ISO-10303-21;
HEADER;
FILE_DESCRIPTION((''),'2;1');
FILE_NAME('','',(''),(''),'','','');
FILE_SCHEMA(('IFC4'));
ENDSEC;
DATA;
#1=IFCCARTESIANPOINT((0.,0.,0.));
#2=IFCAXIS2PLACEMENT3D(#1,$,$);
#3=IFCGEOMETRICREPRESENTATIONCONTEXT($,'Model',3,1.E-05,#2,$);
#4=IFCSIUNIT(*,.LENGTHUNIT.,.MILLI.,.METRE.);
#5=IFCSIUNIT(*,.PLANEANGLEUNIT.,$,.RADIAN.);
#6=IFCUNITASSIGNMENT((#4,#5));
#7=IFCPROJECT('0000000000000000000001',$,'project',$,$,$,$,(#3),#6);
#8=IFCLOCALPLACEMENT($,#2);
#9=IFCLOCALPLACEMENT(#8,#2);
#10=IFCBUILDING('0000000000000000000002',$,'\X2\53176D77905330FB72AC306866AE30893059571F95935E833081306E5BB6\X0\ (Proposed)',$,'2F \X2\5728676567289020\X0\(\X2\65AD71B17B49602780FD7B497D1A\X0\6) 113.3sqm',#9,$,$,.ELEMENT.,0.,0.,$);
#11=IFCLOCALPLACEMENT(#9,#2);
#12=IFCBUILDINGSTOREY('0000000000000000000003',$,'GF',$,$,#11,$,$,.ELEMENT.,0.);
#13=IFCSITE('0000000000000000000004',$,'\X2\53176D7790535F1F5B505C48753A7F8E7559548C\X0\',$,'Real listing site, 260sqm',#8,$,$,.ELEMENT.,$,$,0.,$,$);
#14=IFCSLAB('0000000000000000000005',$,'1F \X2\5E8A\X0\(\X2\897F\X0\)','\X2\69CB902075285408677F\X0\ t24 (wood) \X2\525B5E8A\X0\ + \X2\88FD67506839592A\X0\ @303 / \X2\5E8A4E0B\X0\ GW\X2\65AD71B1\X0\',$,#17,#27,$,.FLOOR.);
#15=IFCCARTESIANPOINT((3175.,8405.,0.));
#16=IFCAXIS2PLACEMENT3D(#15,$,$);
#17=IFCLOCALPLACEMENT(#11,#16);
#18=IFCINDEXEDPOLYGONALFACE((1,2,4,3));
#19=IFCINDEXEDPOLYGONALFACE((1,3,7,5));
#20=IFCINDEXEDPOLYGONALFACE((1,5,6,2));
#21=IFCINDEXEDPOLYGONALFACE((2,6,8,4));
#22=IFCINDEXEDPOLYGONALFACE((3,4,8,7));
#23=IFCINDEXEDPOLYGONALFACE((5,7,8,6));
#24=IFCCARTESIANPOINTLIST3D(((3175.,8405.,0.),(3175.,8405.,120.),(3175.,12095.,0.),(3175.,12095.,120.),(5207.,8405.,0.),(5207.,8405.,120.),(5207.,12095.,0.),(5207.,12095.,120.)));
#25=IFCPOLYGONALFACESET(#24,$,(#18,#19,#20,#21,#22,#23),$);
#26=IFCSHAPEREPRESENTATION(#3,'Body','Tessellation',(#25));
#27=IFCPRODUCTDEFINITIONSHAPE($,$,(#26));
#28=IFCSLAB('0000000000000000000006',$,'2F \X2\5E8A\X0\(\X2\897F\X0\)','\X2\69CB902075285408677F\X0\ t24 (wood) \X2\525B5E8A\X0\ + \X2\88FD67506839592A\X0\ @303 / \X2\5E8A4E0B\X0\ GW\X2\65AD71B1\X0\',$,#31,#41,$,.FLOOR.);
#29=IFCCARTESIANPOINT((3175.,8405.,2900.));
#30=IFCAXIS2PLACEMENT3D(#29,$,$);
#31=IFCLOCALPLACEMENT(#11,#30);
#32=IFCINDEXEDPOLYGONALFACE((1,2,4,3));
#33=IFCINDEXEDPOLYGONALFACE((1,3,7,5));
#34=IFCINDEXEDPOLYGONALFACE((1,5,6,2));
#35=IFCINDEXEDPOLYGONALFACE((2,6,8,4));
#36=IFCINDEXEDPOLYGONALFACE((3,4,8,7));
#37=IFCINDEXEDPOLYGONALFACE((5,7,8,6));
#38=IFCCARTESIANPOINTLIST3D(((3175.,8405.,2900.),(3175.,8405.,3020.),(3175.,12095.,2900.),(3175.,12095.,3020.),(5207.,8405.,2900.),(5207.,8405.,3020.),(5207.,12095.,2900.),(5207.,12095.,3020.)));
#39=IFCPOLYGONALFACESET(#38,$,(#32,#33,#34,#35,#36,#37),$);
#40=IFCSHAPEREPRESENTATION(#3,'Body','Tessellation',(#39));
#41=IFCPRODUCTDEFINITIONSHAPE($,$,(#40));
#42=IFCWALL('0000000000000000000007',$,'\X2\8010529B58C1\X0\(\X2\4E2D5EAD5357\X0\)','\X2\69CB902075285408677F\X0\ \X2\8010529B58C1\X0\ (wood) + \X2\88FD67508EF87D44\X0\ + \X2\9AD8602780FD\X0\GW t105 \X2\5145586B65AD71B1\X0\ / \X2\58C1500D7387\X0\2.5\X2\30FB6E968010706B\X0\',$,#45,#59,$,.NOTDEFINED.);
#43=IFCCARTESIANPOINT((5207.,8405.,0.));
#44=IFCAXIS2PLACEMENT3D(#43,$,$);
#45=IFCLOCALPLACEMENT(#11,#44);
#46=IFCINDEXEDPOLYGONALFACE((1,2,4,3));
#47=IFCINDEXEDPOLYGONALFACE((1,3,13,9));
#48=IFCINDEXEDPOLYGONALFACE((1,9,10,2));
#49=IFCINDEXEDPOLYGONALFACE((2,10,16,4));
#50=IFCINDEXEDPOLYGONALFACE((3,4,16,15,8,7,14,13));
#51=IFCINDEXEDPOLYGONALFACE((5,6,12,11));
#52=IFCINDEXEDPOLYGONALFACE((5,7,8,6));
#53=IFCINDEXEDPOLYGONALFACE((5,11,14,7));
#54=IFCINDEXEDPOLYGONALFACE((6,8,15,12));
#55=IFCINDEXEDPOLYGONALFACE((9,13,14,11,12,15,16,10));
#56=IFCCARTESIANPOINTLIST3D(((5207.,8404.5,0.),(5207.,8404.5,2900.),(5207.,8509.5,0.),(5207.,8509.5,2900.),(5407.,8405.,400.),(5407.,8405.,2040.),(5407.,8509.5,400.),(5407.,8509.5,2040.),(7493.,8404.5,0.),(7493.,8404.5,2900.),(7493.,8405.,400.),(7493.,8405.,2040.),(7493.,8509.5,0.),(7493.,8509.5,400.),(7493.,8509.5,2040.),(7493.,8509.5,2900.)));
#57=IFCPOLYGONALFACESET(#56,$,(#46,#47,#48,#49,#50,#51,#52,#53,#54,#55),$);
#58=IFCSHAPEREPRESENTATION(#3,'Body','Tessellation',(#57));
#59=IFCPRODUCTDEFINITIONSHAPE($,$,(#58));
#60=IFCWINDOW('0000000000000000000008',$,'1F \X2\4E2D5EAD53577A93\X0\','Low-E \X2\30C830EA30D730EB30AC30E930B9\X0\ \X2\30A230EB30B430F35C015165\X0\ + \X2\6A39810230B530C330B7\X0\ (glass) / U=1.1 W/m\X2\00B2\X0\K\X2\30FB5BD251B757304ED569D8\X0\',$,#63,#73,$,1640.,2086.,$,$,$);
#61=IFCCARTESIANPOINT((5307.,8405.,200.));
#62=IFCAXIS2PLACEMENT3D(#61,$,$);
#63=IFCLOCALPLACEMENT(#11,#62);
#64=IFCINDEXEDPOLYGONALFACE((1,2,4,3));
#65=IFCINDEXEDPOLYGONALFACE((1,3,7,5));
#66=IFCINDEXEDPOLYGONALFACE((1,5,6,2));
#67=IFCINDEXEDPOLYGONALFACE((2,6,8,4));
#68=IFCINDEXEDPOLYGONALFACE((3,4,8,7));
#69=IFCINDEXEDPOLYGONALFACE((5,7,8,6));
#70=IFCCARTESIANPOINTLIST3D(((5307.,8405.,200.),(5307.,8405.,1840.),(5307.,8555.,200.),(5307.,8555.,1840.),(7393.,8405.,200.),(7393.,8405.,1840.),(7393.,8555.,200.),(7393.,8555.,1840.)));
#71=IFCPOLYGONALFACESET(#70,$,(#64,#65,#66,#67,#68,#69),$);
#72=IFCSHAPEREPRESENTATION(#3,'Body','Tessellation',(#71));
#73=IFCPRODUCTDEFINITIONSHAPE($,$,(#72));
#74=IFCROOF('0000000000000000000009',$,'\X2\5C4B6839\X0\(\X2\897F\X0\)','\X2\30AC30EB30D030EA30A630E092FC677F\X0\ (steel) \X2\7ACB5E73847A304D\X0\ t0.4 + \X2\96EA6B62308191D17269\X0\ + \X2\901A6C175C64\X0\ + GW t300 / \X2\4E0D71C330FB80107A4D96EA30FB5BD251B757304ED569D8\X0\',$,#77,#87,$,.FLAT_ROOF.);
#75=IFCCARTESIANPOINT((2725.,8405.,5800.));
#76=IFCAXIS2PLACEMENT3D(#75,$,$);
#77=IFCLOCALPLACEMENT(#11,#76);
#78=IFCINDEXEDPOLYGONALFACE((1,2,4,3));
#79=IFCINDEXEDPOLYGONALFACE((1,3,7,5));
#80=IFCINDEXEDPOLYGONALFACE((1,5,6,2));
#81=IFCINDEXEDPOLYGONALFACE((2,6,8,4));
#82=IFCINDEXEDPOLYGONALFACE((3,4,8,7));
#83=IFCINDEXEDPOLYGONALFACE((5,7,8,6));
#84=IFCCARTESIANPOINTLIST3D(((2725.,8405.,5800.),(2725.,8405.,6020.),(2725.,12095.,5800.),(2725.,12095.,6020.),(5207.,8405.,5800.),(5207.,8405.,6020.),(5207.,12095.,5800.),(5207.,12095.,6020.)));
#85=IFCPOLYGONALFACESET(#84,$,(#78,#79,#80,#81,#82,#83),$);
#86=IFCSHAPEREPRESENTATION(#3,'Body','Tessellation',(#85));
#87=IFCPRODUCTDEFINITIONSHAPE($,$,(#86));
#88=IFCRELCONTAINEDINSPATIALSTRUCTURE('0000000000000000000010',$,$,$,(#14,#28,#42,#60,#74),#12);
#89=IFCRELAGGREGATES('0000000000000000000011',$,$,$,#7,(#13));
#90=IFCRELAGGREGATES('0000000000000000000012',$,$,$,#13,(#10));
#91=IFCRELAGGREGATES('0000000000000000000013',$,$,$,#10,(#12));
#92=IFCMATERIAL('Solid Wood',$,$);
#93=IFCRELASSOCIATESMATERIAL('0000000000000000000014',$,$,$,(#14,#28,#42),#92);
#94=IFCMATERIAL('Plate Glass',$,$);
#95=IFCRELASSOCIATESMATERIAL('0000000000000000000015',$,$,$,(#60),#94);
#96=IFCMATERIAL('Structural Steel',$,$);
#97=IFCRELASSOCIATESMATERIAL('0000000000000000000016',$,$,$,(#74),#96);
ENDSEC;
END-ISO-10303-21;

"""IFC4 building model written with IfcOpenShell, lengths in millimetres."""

from ifc_helpers import new_model, si_unit, frame, frame_2d, origin, place, context, project, spatial, rectangle, extrude, material, element, fill, save


model = new_model("IFC4")

# Units and contexts
model_context = context("Model", 3, precision=1e-05, world=origin())
ifc_project = project(units=[si_unit("LENGTHUNIT", "METRE", prefix="MILLI"), si_unit("PLANEANGLEUNIT", "RADIAN")], contexts=[model_context])

# Site, building, storey
site_placement = place(None, origin())
site = spatial("IfcSite", under=ifc_project, at=site_placement, Name="北海道弟子屈町美留和", ObjectType="Real listing site, 260sqm", CompositionType="ELEMENT", RefElevation=0.0)
building_placement = place(site_placement, origin())
building = spatial("IfcBuilding", under=site, at=building_placement, Name="北海道・犬と暮らす土間広めの家 (Proposed)", ObjectType="2F 在来木造(断熱等性能等級6) 113.3sqm", CompositionType="ELEMENT", ElevationOfRefHeight=0.0, ElevationOfTerrain=0.0)
storey_placement = place(building_placement, origin())
storey = spatial("IfcBuildingStorey", under=building, at=storey_placement, Name="GF", CompositionType="ELEMENT", Elevation=0.0)

# Shared definitions
ifc_material_1 = material(Name="Solid Wood")

# Slabs
slab_1_placement = place(storey_placement, frame((3175.0, 8405.0, 0.0)))
element("IfcSlab", 1, at=slab_1_placement, inside=storey, material=ifc_material_1, Name="1F 床(西)", Description="構造用合板 t24 (wood) 剛床 + 製材根太 @303 / 床下 GW断熱", PredefinedType="FLOOR", context=model_context, shape_type="SweptSolid", body=[
    extrude(rectangle(XDim=2032.0, YDim=3690.0, at=frame_2d((1016.0, 1845.0))), frame((3175.0, 8405.0, 0.0)), (0.0, 0.0, 1.0), 120.0),
])
slab_2_placement = place(storey_placement, frame((3175.0, 8405.0, 2900.0)))
element("IfcSlab", 2, at=slab_2_placement, inside=storey, material=ifc_material_1, Name="2F 床(西)", Description="構造用合板 t24 (wood) 剛床 + 製材根太 @303 / 床下 GW断熱", PredefinedType="FLOOR", context=model_context, shape_type="SweptSolid", body=[
    extrude(rectangle(XDim=2032.0, YDim=3690.0, at=frame_2d((1016.0, 1845.0))), frame((3175.0, 8405.0, 2900.0)), (0.0, 0.0, 1.0), 120.0),
])

# Wall, opening, window
wall_1_placement = place(storey_placement, frame((5207.0, 8405.0, 0.0)))
wall_1 = element("IfcWall", 3, at=wall_1_placement, inside=storey, material=ifc_material_1, Name="耐力壁(中庭南)", Description="構造用合板 耐力壁 (wood) + 製材軸組 + 高性能GW t105 充填断熱 / 壁倍率2.5・準耐火", PredefinedType="NOTDEFINED", context=model_context, shape_type="SweptSolid", body=[
    extrude(rectangle(XDim=2286.0, YDim=105.0, at=frame_2d((1143.0, 52.0))), frame((5207.0, 8405.0, 0.0)), (0.0, 0.0, 1.0), 2900.0),
])
opening_placement = place(storey_placement, frame((5307.0, 8405.0, 200.0)))
opening = element("IfcOpeningElement", 4, at=opening_placement, cuts=wall_1, PredefinedType="NOTDEFINED", context=model_context, shape_type="SweptSolid", body=[
    extrude(rectangle(XDim=2086.0, YDim=150.0, at=frame_2d((1043.0, 75.0))), frame((5307.0, 8405.0, 200.0)), (0.0, 0.0, 1.0), 1640.0),
])
ifc_material_2 = material(Name="Plate Glass")
window_placement = place(storey_placement, frame((5307.0, 8405.0, 200.0)))
window = element("IfcWindow", 5, at=window_placement, inside=storey, material=ifc_material_2, Name="1F 中庭南窓", Description="Low-E トリプルガラス アルゴン封入 + 樹脂サッシ (glass) / U=1.1 W/m²K・寒冷地仕様", OverallHeight=1640.0, OverallWidth=2086.0, context=model_context, shape_type="SweptSolid", body=[
    extrude(rectangle(XDim=2086.0, YDim=150.0, at=frame_2d((1043.0, 75.0))), frame((5307.0, 8405.0, 200.0)), (0.0, 0.0, 1.0), 1640.0),
])
fill(opening, window)

# Roof
ifc_material_3 = material(Name="Structural Steel")
for number, where, name in (
    (6, (2725.0, 8405.0, 5800.0), "屋根(西)"),
):
    element("IfcRoof", number, at=place(storey_placement, frame(where)), inside=storey, material=ifc_material_3, Name=name, Description="ガルバリウム鋼板 (steel) 立平葺き t0.4 + 雪止め金物 + 通気層 + GW t300 / 不燃・耐積雪・寒冷地仕様", PredefinedType="FLAT_ROOF", context=model_context, shape_type="SweptSolid", body=[
        extrude(rectangle(XDim=2482.0, YDim=3690.0, at=frame_2d((1241.0, 1845.0))), frame((2725.0, 8405.0, 5800.0)), (0.0, 0.0, 1.0), 220.0),
    ])

save(model, "model.ifc")
